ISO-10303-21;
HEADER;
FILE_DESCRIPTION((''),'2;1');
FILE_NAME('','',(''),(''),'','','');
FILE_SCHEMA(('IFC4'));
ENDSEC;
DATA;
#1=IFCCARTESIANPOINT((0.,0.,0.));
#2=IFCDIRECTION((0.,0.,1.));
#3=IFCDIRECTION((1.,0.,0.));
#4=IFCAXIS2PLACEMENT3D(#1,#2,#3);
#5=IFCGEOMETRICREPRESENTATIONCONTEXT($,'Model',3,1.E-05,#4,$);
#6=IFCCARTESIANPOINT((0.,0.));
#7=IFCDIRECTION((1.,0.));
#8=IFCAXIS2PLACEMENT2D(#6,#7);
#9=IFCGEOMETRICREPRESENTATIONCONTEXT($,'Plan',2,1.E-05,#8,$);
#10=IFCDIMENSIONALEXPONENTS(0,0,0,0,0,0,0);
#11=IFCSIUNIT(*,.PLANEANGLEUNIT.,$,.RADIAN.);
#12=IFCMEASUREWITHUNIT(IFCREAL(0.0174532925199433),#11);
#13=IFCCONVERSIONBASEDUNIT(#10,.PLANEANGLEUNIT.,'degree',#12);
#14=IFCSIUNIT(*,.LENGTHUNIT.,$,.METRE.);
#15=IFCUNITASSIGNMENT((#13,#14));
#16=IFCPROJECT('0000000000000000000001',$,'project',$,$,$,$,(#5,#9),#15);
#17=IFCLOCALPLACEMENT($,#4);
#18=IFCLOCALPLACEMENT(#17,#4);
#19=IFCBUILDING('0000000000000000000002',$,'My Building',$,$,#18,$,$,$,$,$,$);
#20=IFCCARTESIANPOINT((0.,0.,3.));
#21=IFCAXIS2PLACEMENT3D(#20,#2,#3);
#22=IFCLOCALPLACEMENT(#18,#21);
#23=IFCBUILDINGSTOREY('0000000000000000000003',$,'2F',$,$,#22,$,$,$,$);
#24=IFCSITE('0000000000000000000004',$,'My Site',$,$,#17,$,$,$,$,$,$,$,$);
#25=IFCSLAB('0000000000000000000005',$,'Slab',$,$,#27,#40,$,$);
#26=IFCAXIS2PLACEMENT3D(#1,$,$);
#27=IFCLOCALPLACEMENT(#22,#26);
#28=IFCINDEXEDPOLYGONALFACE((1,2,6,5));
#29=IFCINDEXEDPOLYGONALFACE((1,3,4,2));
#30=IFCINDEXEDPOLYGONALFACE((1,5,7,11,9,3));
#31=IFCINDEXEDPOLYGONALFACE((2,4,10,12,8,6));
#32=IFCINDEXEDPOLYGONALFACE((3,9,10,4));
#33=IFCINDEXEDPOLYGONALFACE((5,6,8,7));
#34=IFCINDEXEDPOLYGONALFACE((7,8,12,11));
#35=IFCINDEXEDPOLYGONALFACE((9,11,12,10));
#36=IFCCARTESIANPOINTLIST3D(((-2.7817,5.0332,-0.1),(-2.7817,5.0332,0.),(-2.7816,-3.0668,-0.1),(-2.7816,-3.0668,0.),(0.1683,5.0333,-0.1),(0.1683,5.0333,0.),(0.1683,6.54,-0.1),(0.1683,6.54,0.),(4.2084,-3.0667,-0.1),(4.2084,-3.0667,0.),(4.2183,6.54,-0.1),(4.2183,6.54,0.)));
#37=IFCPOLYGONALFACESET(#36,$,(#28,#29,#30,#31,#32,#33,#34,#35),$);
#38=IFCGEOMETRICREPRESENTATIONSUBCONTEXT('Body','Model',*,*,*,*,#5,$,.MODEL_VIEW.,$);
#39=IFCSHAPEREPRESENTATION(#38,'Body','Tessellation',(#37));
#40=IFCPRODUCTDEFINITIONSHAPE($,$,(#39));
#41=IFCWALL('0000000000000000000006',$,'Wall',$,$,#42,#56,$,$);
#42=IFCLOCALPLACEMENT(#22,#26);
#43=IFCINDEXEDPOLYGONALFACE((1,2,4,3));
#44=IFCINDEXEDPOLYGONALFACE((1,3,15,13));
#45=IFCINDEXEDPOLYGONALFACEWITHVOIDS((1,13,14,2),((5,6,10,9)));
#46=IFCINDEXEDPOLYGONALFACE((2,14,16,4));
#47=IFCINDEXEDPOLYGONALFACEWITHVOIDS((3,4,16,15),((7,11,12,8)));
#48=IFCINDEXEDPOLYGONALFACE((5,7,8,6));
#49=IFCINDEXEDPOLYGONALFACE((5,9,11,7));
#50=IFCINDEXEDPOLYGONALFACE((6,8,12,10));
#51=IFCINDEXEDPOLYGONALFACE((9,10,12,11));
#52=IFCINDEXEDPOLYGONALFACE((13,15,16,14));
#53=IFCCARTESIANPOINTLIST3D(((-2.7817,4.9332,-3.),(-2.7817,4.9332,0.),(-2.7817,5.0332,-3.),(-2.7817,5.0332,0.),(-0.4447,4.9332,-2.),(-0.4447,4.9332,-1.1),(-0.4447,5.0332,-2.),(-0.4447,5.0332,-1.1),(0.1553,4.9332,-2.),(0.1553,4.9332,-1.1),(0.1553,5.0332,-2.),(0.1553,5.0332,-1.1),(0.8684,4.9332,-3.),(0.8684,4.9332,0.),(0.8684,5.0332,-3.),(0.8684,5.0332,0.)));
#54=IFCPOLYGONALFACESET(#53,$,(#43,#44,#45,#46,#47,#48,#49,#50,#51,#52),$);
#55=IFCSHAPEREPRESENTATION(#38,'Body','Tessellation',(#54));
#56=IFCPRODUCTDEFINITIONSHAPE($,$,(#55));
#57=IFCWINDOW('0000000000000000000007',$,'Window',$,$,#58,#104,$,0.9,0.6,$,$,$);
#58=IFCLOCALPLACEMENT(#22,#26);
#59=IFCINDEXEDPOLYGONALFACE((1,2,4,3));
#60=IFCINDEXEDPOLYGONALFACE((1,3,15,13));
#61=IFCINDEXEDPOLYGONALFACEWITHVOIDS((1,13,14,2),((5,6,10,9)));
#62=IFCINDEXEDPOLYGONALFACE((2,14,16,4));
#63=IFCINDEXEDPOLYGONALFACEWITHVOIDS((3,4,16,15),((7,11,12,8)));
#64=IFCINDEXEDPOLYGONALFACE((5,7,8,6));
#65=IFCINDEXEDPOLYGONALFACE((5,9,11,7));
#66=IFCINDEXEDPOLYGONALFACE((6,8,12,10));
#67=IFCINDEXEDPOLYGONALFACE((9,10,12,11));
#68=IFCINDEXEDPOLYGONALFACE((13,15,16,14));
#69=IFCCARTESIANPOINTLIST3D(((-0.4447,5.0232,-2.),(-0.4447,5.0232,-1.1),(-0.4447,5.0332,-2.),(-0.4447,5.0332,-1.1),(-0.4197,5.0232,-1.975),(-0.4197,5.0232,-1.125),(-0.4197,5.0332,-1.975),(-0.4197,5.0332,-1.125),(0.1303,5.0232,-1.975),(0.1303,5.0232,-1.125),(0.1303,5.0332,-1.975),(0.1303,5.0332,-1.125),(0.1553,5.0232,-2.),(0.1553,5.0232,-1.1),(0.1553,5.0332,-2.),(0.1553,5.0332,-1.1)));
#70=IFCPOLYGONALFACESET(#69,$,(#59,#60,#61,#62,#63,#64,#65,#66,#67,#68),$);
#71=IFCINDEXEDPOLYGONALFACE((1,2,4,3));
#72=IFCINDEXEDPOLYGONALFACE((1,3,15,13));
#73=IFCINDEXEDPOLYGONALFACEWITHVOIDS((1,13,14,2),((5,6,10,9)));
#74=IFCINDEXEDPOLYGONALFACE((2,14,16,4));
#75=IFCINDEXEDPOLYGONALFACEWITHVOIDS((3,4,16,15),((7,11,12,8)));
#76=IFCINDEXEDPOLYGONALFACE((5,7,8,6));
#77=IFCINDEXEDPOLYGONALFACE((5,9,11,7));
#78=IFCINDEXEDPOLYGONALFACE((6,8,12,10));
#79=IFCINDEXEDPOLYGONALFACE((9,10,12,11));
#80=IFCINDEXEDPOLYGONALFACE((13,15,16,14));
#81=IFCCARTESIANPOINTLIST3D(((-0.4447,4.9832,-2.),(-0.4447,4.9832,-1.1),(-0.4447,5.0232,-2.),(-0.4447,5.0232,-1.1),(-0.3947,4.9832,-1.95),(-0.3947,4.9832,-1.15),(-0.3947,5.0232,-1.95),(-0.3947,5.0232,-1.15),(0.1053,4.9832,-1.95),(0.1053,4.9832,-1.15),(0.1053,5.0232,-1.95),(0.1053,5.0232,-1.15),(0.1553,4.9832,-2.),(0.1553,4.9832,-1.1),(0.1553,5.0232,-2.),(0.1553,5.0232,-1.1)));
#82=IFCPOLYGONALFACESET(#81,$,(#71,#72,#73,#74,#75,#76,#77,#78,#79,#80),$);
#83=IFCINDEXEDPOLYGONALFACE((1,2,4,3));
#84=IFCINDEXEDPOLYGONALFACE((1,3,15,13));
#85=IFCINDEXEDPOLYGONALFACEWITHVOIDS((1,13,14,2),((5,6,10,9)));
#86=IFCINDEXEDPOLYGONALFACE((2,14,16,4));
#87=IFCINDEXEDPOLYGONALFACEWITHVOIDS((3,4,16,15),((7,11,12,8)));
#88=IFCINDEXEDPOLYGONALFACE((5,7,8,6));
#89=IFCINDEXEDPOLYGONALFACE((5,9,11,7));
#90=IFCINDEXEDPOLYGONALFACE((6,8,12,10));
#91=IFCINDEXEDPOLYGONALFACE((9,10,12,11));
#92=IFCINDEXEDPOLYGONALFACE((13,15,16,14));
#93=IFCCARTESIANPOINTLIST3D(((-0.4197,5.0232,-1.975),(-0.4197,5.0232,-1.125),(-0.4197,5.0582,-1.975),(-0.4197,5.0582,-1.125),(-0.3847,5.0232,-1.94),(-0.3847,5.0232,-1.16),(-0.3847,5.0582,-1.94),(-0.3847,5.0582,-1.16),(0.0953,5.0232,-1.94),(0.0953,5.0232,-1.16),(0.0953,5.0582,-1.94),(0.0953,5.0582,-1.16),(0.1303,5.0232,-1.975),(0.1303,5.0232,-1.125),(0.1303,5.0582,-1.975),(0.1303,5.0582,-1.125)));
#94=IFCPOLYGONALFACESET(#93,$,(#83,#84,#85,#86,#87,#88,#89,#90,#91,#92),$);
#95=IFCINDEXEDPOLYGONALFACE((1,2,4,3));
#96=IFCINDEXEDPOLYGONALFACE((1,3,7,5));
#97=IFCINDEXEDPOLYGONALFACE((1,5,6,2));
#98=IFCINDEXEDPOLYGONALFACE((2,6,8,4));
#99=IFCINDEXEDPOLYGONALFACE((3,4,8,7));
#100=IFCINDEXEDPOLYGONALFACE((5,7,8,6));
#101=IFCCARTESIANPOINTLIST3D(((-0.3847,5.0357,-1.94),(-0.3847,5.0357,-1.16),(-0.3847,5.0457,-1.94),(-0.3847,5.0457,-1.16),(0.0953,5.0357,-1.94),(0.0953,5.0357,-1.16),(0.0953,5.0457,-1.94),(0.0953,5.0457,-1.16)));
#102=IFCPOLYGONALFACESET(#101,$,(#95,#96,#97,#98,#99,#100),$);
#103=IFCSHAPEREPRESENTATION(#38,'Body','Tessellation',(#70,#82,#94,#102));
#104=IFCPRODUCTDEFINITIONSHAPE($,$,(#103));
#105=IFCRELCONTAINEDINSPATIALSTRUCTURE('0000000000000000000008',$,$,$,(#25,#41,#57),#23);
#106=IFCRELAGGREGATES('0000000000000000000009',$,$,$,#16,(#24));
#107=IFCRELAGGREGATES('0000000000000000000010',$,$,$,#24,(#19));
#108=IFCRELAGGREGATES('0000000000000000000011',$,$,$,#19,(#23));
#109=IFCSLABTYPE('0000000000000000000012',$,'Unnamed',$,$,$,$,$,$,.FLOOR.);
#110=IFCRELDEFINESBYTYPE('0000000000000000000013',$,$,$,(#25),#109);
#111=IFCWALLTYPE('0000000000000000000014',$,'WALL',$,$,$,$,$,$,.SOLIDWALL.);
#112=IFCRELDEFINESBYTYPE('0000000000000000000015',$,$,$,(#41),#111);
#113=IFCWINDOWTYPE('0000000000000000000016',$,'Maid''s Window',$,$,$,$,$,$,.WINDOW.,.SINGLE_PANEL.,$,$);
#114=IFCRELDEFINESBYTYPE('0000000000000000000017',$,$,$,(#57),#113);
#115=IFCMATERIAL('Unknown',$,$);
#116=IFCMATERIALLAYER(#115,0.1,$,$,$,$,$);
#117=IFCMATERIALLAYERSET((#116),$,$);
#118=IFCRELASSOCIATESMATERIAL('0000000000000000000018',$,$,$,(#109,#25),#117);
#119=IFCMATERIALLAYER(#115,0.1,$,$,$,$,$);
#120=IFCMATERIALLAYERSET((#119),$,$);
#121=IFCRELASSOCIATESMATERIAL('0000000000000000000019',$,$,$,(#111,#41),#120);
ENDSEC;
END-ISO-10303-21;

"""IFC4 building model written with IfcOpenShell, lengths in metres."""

from ifc_helpers import new_model, entity, si_unit, converted_unit, frame, origin_with_axes, origin_2d_with_axis, place, context, subcontext, project, spatial, line, indexed_curve, outline, extrude, shape, source, transform, mapped, material, layer, layer_set, layer_usage, type_object, type_shapes, element, fill, save


model = new_model("IFC4")

# Units and contexts
model_context = context("Model", 3, precision=1e-05, world=origin_with_axes())
plan_context = context("Plan", 2, precision=1e-05, world=origin_2d_with_axis())
body_context_1 = subcontext(model_context, "Body", "Model", "MODEL_VIEW")
body_context_2 = subcontext(plan_context, "Body", "Plan", "PLAN_VIEW")
ifc_project = project(units=[converted_unit("PLANEANGLEUNIT", "degree", entity("IfcReal", 0.0174532925199433), si_unit("PLANEANGLEUNIT", "RADIAN"), dimensions=[0, 0, 0, 0, 0, 0, 0]), si_unit("LENGTHUNIT", "METRE")], contexts=[model_context, plan_context])

# Site, building, storey
site_placement = place(None, origin_with_axes())
site = spatial("IfcSite", under=ifc_project, at=site_placement, Name="My Site")
building_placement = place(site_placement, origin_with_axes())
building = spatial("IfcBuilding", under=site, at=building_placement, Name="My Building")
storey_placement = place(building_placement, frame((0.0, 0.0, 3.0), z_axis=(0.0, 0.0, 1.0), x_axis=(1.0, 0.0, 0.0)))
storey = spatial("IfcBuildingStorey", under=building, at=storey_placement, Name="2F")

# Slab
ifc_material = material(Name="Unknown")
ifc_layer_1 = layer(ifc_material, 0.1)
ifc_layer_set_1 = layer_set([ifc_layer_1])
ifc_layer_usage_1 = layer_usage(ifc_layer_set_1, "AXIS3", "POSITIVE", -0.1)
slab_type = type_object("IfcSlabType", Name="Unnamed", PredefinedType="FLOOR", material=ifc_layer_set_1)
slab_placement = place(storey_placement, frame((4.2183, 6.54, 0.0), z_axis=(0.0, 0.0, 1.0), x_axis=(1.0, 0.0, 0.0)))
element("IfcSlab", 1, at=slab_placement, inside=storey, type_object=slab_type, material=ifc_layer_usage_1, Name="Slab", context=body_context_1, shape_type="SweptSolid", body=[
    extrude(outline(indexed_curve([(0.0, 0.0), (-4.05, 0.0), (-4.05, -1.5067), (-7.0, -1.5067), (-6.9999, -9.6067), (-0.0099, -9.6067), (0.0, 0.0)])), frame((0.0, 0.0, -0.1), z_axis=(0.0, 0.0, 1.0), x_axis=(1.0, 0.0, 0.0)), (0.0, 0.0, 1.0), 0.1),
])

# Wall, opening, window
ifc_layer_2 = layer(ifc_material, 0.1)
ifc_layer_set_2 = layer_set([ifc_layer_2])
ifc_layer_usage_2 = layer_usage(ifc_layer_set_2, "AXIS2", "POSITIVE", 0.0)
wall_type = type_object("IfcWallType", Name="WALL", PredefinedType="SOLIDWALL", material=ifc_layer_set_2)
wall_1_placement = place(storey_placement, frame((-2.7817, 4.9332, -3.0), z_axis=(0.0, 0.0, 1.0), x_axis=(1.0, 0.0, 0.0)))
wall_1 = element("IfcWall", 2, at=wall_1_placement, inside=storey, type_object=wall_type, material=ifc_layer_usage_2, Name="Wall", context=body_context_1, shape_type="SweptSolid", body=[
    extrude(outline(indexed_curve([(0.0, 0.0), (0.0, 0.1), (3.6501, 0.1), (3.6501, 0.0)], segments=[line(1, 2, 3, 4, 1)])), origin_with_axes(), (0.0, 0.0, 1.0), 3.0),
])
shared_shape_1 = source(origin_with_axes(), body_context_1, "Body", "SweptSolid", [
    extrude(outline(indexed_curve([(0.0, 0.0), (0.6, 0.0), (0.6, 0.9), (0.0, 0.9)], segments=[line(1, 2, 3, 4, 1)])), frame((0.0, -0.6, 0.0), z_axis=(0.0, -1.0, 0.0), x_axis=(1.0, 0.0, 0.0)), (0.0, 0.0, -1.0), 1.2),
])
opening_1_placement = place(wall_1_placement, frame((2.337, 0.0, 1.0), z_axis=(0.0, 0.0, 1.0), x_axis=(1.0, 0.0, 0.0)))
opening_1 = element("IfcOpeningElement", 3, at=opening_1_placement, cuts=wall_1, PredefinedType="OPENING", context=body_context_1, shape_type="MappedRepresentation", body=[
    mapped(shared_shape_1, transform((0.0, 0.0, 0.0), x_axis=(1.0, 0.0, 0.0), y_axis=(0.0, 1.0, 0.0), z_axis=(0.0, 0.0, 1.0), scale=1.0)),
])
window_type_1 = type_object("IfcWindowType", Name="Maid's Window", PartitioningType="SINGLE_PANEL", PredefinedType="WINDOW")
shared_shape_2 = source(origin_with_axes(), body_context_1, "Body", "SweptSolid", [
    extrude(outline(indexed_curve([(0.0, 0.0), (0.6, 0.0), (0.6, 0.9), (0.0, 0.9)], segments=[line(1, 2, 3, 4, 1)]), holes=[indexed_curve([(0.025, 0.025), (0.575, 0.025), (0.575, 0.875), (0.025, 0.875)], segments=[line(1, 2, 3, 4, 1)])]), frame((0.0, 0.09, 0.0), z_axis=(0.0, -1.0, 0.0), x_axis=(1.0, 0.0, 0.0)), (0.0, 0.0, -1.0), 0.01),
    extrude(outline(indexed_curve([(0.0, 0.0), (0.6, 0.0), (0.6, 0.9), (0.0, 0.9)], segments=[line(1, 2, 3, 4, 1)]), holes=[indexed_curve([(0.05, 0.05), (0.55, 0.05), (0.55, 0.85), (0.05, 0.85)], segments=[line(1, 2, 3, 4, 1)])]), frame((0.0, 0.05, 0.0), z_axis=(0.0, -1.0, 0.0), x_axis=(1.0, 0.0, 0.0)), (0.0, 0.0, -1.0), 0.04),
    extrude(outline(indexed_curve([(0.0, 0.0), (0.55, 0.0), (0.55, 0.85), (0.0, 0.85)], segments=[line(1, 2, 3, 4, 1)]), holes=[indexed_curve([(0.035, 0.035), (0.515, 0.035), (0.515, 0.815), (0.035, 0.815)], segments=[line(1, 2, 3, 4, 1)])]), frame((0.025, 0.09, 0.025), z_axis=(0.0, -1.0, 0.0), x_axis=(1.0, 0.0, 0.0)), (0.0, 0.0, -1.0), 0.035),
    extrude(outline(indexed_curve([(0.035, 0.035), (0.515, 0.035), (0.515, 0.815), (0.035, 0.815)], segments=[line(1, 2, 3, 4, 1)])), frame((0.025, 0.1025, 0.025), z_axis=(0.0, -1.0, 0.0), x_axis=(1.0, 0.0, 0.0)), (0.0, 0.0, -1.0), 0.01),
])
shared_shape_3 = source(origin_with_axes(), body_context_2, "Body", "Curve2D", [
    entity("IfcIndexedPolyCurve", entity("IfcCartesianPointList2D", [[0.05, 0.05], [0.55, 0.05]])),
    entity("IfcIndexedPolyCurve", entity("IfcCartesianPointList2D", [[0.0, 0.1], [0.025, 0.1], [0.025, 0.09], [0.05, 0.09], [0.05, 0.05], [0.0, 0.05]]), [entity("IfcLineIndex", [1, 2, 3, 4, 5, 6, 1])]),
    entity("IfcIndexedPolyCurve", entity("IfcCartesianPointList2D", [[0.6, 0.1], [0.575, 0.1], [0.575, 0.09], [0.55, 0.09], [0.55, 0.05], [0.6, 0.05]]), [entity("IfcLineIndex", [1, 2, 3, 4, 5, 6, 1])]),
    entity("IfcIndexedPolyCurve", entity("IfcCartesianPointList2D", [[0.025, 0.09], [0.06, 0.09], [0.06, 0.125], [0.025, 0.125]]), [entity("IfcLineIndex", [1, 2, 3, 4, 1])]),
    entity("IfcIndexedPolyCurve", entity("IfcCartesianPointList2D", [[0.575, 0.09], [0.54, 0.09], [0.54, 0.125], [0.575, 0.125]]), [entity("IfcLineIndex", [1, 2, 3, 4, 1])]),
    entity("IfcIndexedPolyCurve", entity("IfcCartesianPointList2D", [[0.06, 0.09], [0.54, 0.09]])),
    entity("IfcIndexedPolyCurve", entity("IfcCartesianPointList2D", [[0.06, 0.125], [0.54, 0.125]])),
    entity("IfcIndexedPolyCurve", entity("IfcCartesianPointList2D", [[0.06, 0.1075], [0.54, 0.1075]])),
])
type_shapes(window_type_1, [shared_shape_2, shared_shape_3])
window_1_placement = place(opening_1_placement, frame((0.0, 0.0, 0.0), z_axis=(0.0, 0.0, 1.0), x_axis=(1.0, 0.0, 0.0)))
window_1 = element("IfcWindow", 4, at=window_1_placement, inside=storey, type_object=window_type_1, Name="Window", OverallHeight=0.9, OverallWidth=0.6, shapes=[
    shape(body_context_1, "Body", "MappedRepresentation", [mapped(shared_shape_2, transform((0.0, 0.0, 0.0), x_axis=(1.0, 0.0, 0.0), y_axis=(0.0, 1.0, 0.0), z_axis=(0.0, 0.0, 1.0), scale=1.0))]),
    shape(body_context_2, "Body", "MappedRepresentation", [mapped(shared_shape_3, transform((0.0, 0.0, 0.0), x_axis=(1.0, 0.0, 0.0), y_axis=(0.0, 1.0, 0.0), z_axis=(0.0, 0.0, 1.0), scale=1.0))]),
])
fill(opening_1, window_1)

save(model, "model.ifc")
